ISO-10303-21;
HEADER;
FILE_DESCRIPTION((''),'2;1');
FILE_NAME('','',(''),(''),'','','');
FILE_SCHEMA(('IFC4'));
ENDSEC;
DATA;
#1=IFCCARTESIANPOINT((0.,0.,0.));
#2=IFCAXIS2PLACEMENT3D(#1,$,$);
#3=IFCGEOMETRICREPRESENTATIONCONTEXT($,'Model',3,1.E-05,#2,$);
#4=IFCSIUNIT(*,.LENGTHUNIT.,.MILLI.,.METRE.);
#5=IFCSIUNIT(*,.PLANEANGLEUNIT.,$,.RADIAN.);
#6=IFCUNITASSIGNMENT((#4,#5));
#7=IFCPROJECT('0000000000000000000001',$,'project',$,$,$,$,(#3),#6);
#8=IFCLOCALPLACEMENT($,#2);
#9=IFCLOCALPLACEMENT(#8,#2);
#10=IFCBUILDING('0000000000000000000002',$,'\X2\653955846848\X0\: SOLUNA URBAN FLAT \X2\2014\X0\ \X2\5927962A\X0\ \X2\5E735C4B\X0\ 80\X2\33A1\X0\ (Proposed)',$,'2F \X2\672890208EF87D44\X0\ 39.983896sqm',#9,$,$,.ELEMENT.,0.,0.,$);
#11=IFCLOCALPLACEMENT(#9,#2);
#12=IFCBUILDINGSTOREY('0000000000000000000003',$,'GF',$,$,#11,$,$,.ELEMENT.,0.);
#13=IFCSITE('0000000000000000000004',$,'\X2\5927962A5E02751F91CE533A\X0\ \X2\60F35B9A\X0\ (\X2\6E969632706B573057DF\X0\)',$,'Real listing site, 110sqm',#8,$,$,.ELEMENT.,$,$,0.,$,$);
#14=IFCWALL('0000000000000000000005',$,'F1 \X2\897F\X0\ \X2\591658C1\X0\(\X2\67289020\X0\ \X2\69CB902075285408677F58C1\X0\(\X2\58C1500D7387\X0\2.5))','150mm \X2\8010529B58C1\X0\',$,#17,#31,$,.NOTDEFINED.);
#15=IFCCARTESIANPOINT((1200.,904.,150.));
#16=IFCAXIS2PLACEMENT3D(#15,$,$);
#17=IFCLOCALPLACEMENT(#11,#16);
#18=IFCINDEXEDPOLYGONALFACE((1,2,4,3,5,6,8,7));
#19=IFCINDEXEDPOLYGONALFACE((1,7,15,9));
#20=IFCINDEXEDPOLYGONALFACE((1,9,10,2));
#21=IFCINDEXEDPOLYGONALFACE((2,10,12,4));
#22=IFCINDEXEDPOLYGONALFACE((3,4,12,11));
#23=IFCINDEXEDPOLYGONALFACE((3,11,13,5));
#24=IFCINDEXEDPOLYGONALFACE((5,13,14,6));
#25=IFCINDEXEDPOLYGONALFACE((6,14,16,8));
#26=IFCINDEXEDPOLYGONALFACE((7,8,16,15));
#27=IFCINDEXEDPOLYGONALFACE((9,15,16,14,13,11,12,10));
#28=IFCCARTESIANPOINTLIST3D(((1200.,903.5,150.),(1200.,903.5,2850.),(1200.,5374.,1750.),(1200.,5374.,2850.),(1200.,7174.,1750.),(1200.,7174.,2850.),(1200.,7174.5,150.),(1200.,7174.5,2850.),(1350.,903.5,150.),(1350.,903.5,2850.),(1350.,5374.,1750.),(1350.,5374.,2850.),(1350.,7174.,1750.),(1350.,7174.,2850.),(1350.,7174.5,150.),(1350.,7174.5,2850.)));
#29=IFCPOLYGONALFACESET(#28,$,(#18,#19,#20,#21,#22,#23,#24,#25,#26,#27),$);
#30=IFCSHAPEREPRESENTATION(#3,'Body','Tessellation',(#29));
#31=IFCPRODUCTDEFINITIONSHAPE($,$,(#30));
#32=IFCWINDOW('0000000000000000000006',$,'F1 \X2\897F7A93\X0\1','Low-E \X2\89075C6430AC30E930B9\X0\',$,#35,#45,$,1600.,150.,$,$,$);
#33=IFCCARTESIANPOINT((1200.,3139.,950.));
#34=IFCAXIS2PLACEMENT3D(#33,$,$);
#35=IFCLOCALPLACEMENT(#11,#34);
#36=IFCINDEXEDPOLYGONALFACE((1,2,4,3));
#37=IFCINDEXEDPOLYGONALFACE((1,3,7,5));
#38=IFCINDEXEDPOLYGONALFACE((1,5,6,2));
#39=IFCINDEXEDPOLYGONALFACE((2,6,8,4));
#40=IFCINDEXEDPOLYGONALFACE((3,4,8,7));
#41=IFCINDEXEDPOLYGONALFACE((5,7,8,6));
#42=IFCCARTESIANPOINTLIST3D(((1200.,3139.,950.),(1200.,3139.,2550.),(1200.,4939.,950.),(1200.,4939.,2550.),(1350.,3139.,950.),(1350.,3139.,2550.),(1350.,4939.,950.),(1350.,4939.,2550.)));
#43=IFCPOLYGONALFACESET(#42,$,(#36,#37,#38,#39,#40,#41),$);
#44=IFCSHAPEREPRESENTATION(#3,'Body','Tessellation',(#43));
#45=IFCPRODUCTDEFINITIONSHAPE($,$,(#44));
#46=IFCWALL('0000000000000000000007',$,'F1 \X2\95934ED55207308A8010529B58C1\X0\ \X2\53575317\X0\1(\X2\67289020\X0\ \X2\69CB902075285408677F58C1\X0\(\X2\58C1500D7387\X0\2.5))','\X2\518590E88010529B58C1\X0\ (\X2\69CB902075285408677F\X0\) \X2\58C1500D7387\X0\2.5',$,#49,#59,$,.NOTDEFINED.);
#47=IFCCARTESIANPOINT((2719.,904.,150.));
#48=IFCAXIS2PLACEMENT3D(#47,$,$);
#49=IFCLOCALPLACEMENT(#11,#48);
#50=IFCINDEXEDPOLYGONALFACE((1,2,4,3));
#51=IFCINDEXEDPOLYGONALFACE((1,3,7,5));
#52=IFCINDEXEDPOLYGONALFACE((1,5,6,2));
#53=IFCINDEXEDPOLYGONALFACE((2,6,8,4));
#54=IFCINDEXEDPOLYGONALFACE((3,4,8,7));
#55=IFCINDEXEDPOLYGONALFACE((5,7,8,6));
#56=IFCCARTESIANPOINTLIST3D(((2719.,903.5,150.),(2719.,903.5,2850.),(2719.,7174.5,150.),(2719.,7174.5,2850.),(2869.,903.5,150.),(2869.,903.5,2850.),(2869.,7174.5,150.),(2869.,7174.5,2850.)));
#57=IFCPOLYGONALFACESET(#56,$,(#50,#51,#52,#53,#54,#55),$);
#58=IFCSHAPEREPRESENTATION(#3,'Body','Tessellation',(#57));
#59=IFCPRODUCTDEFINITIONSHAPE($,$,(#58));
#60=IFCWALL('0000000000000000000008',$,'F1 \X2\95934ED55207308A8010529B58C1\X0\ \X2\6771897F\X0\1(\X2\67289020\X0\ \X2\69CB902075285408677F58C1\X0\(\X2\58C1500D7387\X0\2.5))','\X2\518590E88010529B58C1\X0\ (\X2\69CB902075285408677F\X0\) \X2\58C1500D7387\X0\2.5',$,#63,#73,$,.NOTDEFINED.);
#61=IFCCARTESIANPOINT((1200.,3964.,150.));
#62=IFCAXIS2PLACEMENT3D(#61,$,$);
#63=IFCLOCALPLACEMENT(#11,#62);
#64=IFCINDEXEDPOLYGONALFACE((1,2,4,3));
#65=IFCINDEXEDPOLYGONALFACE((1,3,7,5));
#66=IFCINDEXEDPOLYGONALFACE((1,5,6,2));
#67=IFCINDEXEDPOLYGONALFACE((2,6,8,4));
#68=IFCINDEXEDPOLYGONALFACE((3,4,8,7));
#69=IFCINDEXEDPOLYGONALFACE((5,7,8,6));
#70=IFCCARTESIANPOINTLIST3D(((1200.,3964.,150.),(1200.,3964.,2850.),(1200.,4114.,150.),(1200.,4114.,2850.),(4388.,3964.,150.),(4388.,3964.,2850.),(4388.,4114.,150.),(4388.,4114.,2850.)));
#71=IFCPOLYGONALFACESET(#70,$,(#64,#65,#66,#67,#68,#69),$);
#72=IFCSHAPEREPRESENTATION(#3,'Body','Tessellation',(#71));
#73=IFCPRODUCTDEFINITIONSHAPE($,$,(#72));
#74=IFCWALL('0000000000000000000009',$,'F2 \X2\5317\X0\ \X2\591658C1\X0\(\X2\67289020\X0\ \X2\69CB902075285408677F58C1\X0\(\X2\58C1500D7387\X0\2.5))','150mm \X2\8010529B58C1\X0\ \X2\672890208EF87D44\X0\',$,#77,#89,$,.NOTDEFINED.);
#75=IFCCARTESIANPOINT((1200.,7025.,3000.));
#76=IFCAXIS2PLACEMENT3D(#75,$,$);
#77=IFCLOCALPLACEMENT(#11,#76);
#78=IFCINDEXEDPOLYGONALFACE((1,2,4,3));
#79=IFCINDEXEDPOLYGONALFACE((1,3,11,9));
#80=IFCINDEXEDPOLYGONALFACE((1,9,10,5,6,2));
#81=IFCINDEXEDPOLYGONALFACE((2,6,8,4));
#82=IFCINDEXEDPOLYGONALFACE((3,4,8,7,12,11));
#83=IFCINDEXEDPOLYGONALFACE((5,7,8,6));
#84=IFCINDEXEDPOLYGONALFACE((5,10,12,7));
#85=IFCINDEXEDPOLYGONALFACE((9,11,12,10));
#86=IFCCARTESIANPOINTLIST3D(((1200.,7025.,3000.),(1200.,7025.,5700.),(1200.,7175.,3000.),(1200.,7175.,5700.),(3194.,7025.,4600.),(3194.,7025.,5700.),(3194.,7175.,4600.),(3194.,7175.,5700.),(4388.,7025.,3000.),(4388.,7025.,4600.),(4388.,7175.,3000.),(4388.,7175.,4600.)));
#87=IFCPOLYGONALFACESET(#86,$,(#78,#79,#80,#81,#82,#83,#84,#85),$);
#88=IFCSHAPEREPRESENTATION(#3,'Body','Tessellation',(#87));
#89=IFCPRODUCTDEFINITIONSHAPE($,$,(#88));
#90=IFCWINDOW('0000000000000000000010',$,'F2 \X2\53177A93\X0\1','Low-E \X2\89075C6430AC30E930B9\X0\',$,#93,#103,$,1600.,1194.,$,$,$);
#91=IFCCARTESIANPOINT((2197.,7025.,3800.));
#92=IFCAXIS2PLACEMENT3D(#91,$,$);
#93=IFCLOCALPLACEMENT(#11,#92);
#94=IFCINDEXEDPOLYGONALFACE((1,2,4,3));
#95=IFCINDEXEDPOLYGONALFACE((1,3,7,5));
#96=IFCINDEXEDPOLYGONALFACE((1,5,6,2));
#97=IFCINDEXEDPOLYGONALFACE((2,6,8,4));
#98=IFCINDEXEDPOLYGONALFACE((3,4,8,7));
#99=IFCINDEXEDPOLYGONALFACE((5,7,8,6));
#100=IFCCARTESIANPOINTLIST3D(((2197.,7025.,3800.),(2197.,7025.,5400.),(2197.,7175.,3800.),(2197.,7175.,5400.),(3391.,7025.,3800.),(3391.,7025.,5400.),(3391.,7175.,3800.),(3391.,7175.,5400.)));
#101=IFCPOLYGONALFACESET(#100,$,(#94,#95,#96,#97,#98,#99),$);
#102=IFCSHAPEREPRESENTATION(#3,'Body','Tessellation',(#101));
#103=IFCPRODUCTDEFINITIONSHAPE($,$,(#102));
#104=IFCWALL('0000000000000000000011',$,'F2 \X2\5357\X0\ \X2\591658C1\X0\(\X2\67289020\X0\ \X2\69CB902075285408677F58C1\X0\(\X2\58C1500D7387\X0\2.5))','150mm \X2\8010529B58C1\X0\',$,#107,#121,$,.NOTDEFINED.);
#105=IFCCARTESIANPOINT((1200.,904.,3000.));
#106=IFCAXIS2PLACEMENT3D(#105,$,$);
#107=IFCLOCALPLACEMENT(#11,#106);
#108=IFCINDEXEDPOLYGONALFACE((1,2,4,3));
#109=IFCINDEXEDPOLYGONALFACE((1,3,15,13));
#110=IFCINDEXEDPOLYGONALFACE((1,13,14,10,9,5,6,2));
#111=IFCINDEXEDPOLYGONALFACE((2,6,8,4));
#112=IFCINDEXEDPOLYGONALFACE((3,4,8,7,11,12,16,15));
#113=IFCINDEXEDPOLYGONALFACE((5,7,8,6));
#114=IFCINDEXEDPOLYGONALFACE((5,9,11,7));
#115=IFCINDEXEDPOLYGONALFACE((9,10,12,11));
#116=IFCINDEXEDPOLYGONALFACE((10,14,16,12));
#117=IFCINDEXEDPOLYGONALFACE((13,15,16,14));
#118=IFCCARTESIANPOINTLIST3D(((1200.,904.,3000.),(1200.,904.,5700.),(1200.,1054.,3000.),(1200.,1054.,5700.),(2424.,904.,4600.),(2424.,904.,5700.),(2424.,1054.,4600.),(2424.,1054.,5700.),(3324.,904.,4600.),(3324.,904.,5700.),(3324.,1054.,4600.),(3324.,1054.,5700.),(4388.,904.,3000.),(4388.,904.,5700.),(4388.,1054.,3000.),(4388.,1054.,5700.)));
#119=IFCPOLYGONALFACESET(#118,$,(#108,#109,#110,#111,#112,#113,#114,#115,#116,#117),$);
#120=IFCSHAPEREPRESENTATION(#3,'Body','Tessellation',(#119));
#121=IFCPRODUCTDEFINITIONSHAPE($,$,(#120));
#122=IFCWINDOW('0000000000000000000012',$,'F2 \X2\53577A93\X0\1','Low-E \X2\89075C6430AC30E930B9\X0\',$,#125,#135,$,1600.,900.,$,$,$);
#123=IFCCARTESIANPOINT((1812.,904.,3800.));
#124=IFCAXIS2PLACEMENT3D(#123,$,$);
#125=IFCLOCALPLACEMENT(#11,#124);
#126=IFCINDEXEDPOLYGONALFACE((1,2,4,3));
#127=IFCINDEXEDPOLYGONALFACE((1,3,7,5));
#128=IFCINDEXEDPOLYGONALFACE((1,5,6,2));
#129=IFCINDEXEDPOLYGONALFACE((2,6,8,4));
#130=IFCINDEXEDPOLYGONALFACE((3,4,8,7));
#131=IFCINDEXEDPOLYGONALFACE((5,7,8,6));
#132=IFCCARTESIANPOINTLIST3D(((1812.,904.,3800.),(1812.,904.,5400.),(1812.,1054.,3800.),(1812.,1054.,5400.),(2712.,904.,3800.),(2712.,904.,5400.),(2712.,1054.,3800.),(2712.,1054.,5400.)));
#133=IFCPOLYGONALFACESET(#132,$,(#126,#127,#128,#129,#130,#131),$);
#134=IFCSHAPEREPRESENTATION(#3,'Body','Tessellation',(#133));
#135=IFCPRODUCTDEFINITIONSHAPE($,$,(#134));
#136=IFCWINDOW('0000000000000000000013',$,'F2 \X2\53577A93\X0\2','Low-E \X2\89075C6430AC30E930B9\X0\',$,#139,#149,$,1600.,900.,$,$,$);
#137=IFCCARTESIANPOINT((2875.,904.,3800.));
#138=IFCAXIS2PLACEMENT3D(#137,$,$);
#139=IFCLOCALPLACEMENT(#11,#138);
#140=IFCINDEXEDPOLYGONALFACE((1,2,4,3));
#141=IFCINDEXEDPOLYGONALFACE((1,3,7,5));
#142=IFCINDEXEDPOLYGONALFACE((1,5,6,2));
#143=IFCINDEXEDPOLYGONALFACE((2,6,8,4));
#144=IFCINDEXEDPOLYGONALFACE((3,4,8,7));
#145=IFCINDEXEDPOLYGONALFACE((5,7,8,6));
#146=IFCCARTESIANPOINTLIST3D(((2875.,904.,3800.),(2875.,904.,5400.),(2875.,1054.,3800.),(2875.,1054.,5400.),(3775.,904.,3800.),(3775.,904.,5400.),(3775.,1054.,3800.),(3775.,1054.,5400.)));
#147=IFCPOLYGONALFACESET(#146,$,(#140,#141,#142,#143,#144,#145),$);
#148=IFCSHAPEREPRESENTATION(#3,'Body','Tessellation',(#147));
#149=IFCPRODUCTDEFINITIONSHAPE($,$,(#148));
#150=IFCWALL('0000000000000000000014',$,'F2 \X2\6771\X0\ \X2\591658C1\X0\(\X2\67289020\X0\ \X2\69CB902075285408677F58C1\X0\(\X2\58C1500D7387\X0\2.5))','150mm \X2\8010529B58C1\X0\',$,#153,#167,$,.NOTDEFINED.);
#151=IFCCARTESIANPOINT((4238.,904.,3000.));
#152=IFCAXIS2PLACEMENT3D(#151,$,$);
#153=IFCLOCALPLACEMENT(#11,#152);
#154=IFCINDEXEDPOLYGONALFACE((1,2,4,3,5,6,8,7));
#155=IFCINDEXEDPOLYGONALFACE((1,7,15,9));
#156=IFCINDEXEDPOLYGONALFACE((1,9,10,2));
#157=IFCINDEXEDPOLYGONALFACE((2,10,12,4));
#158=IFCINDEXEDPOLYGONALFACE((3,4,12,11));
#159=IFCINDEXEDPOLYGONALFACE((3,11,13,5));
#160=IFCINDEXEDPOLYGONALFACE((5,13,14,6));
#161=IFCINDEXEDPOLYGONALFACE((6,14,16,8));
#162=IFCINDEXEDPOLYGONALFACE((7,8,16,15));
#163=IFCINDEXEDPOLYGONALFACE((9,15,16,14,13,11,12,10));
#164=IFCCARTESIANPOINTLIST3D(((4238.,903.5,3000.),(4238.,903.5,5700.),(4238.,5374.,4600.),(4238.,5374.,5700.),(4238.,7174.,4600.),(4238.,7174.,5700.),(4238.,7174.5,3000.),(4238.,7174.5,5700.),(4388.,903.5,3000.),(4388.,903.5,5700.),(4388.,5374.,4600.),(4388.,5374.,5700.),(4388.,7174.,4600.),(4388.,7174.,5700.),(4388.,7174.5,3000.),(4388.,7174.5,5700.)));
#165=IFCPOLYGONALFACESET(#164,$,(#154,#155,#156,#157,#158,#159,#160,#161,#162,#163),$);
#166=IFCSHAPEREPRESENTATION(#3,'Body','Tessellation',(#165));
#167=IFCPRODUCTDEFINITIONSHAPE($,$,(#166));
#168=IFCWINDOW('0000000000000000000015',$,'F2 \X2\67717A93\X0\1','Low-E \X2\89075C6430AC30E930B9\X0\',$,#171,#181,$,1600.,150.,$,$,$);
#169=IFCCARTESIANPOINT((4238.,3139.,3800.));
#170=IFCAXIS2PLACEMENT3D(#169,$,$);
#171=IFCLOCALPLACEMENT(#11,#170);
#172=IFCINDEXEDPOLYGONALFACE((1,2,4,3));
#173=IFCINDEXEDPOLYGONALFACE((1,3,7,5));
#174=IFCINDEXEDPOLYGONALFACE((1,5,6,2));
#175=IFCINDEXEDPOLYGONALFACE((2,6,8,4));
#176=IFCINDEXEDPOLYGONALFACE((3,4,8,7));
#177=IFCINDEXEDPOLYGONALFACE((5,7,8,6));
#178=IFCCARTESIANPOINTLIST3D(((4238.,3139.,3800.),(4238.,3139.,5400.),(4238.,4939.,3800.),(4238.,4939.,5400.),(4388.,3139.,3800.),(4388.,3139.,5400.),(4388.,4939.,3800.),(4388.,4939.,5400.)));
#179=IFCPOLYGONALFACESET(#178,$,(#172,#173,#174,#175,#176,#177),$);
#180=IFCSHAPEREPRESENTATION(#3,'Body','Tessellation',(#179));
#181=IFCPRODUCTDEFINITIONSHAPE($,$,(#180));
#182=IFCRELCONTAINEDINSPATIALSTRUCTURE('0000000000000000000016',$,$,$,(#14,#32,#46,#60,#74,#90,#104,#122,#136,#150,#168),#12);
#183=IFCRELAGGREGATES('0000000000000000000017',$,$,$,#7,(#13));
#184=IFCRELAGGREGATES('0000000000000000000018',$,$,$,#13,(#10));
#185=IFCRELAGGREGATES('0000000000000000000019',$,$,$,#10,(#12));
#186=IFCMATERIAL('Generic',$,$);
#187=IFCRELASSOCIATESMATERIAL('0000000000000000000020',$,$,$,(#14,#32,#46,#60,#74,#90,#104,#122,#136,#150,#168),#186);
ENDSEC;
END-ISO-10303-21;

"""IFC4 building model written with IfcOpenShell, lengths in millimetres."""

from ifc_helpers import new_model, si_unit, frame, frame_2d, origin, place, context, project, spatial, rectangle, extrude, material, element, fill, save


model = new_model("IFC4")

# Units and contexts
model_context = context("Model", 3, precision=1e-05, world=origin())
ifc_project = project(units=[si_unit("LENGTHUNIT", "METRE", prefix="MILLI"), si_unit("PLANEANGLEUNIT", "RADIAN")], contexts=[model_context])

# Site, building, storey
site_placement = place(None, origin())
site = spatial("IfcSite", under=ifc_project, at=site_placement, Name="大阪市生野区 想定 (準防火地域)", ObjectType="Real listing site, 110sqm", CompositionType="ELEMENT", RefElevation=0.0)
building_placement = place(site_placement, origin())
building = spatial("IfcBuilding", under=site, at=building_placement, Name="改善案: SOLUNA URBAN FLAT — 大阪 平屋 80㎡ (Proposed)", ObjectType="2F 木造軸組 39.983896sqm", CompositionType="ELEMENT", ElevationOfRefHeight=0.0, ElevationOfTerrain=0.0)
storey_placement = place(building_placement, origin())
storey = spatial("IfcBuildingStorey", under=building, at=storey_placement, Name="GF", CompositionType="ELEMENT", Elevation=0.0)

# Shared definitions
ifc_material_1 = material(Name="Generic")

# Wall, opening, window
wall_1_placement = place(storey_placement, frame((1200.0, 904.0, 150.0)))
wall_1 = element("IfcWall", 1, at=wall_1_placement, inside=storey, material=ifc_material_1, Name="F1 西 外壁(木造 構造用合板壁(壁倍率2.5))", Description="150mm 耐力壁", PredefinedType="NOTDEFINED", context=model_context, shape_type="SweptSolid", body=[
    extrude(rectangle(XDim=150.0, YDim=6271.0, at=frame_2d((75.0, 3135.0))), frame((1200.0, 904.0, 150.0)), (0.0, 0.0, 1.0), 2700.0),
])
opening_1_placement = place(storey_placement, frame((1200.0, 3139.0, 950.0)))
opening_1 = element("IfcOpeningElement", 2, at=opening_1_placement, cuts=wall_1, PredefinedType="NOTDEFINED", context=model_context, shape_type="SweptSolid", body=[
    extrude(rectangle(XDim=150.0, YDim=1800.0, at=frame_2d((75.0, 900.0))), frame((1200.0, 3139.0, 950.0)), (0.0, 0.0, 1.0), 1600.0),
])
window_1_placement = place(storey_placement, frame((1200.0, 3139.0, 950.0)))
window_1 = element("IfcWindow", 3, at=window_1_placement, inside=storey, material=ifc_material_1, Name="F1 西窓1", Description="Low-E 複層ガラス", OverallHeight=1600.0, OverallWidth=150.0, context=model_context, shape_type="SweptSolid", body=[
    extrude(rectangle(XDim=150.0, YDim=1800.0, at=frame_2d((75.0, 900.0))), frame((1200.0, 3139.0, 950.0)), (0.0, 0.0, 1.0), 1600.0),
])
fill(opening_1, window_1)

# Walls
wall_2_placement = place(storey_placement, frame((2719.0, 904.0, 150.0)))
element("IfcWall", 4, at=wall_2_placement, inside=storey, material=ifc_material_1, Name="F1 間仕切り耐力壁 南北1(木造 構造用合板壁(壁倍率2.5))", Description="内部耐力壁 (構造用合板) 壁倍率2.5", PredefinedType="NOTDEFINED", context=model_context, shape_type="SweptSolid", body=[
    extrude(rectangle(XDim=150.0, YDim=6271.0, at=frame_2d((75.0, 3135.0))), frame((2719.0, 904.0, 150.0)), (0.0, 0.0, 1.0), 2700.0),
])
wall_3_placement = place(storey_placement, frame((1200.0, 3964.0, 150.0)))
element("IfcWall", 5, at=wall_3_placement, inside=storey, material=ifc_material_1, Name="F1 間仕切り耐力壁 東西1(木造 構造用合板壁(壁倍率2.5))", Description="内部耐力壁 (構造用合板) 壁倍率2.5", PredefinedType="NOTDEFINED", context=model_context, shape_type="SweptSolid", body=[
    extrude(rectangle(XDim=3188.0, YDim=150.0, at=frame_2d((1594.0, 75.0))), frame((1200.0, 3964.0, 150.0)), (0.0, 0.0, 1.0), 2700.0),
])

# Wall, opening, window
wall_4_placement = place(storey_placement, frame((1200.0, 7025.0, 3000.0)))
wall_4 = element("IfcWall", 6, at=wall_4_placement, inside=storey, material=ifc_material_1, Name="F2 北 外壁(木造 構造用合板壁(壁倍率2.5))", Description="150mm 耐力壁 木造軸組", PredefinedType="NOTDEFINED", context=model_context, shape_type="SweptSolid", body=[
    extrude(rectangle(XDim=3188.0, YDim=150.0, at=frame_2d((1594.0, 75.0))), frame((1200.0, 7025.0, 3000.0)), (0.0, 0.0, 1.0), 2700.0),
])
opening_2_placement = place(storey_placement, frame((2197.0, 7025.0, 3800.0)))
opening_2 = element("IfcOpeningElement", 7, at=opening_2_placement, cuts=wall_4, PredefinedType="NOTDEFINED", context=model_context, shape_type="SweptSolid", body=[
    extrude(rectangle(XDim=1194.0, YDim=150.0, at=frame_2d((597.0, 75.0))), frame((2197.0, 7025.0, 3800.0)), (0.0, 0.0, 1.0), 1600.0),
])
window_2_placement = place(storey_placement, frame((2197.0, 7025.0, 3800.0)))
window_2 = element("IfcWindow", 8, at=window_2_placement, inside=storey, material=ifc_material_1, Name="F2 北窓1", Description="Low-E 複層ガラス", OverallHeight=1600.0, OverallWidth=1194.0, context=model_context, shape_type="SweptSolid", body=[
    extrude(rectangle(XDim=1194.0, YDim=150.0, at=frame_2d((597.0, 75.0))), frame((2197.0, 7025.0, 3800.0)), (0.0, 0.0, 1.0), 1600.0),
])
fill(opening_2, window_2)

# Wall, openings, windows
wall_5_placement = place(storey_placement, frame((1200.0, 904.0, 3000.0)))
wall_5 = element("IfcWall", 9, at=wall_5_placement, inside=storey, material=ifc_material_1, Name="F2 南 外壁(木造 構造用合板壁(壁倍率2.5))", Description="150mm 耐力壁", PredefinedType="NOTDEFINED", context=model_context, shape_type="SweptSolid", body=[
    extrude(rectangle(XDim=3188.0, YDim=150.0, at=frame_2d((1594.0, 75.0))), frame((1200.0, 904.0, 3000.0)), (0.0, 0.0, 1.0), 2700.0),
])
opening_3_placement = place(storey_placement, frame((1812.0, 904.0, 3800.0)))
opening_3 = element("IfcOpeningElement", 10, at=opening_3_placement, cuts=wall_5, PredefinedType="NOTDEFINED", context=model_context, shape_type="SweptSolid", body=[
    extrude(rectangle(XDim=900.0, YDim=150.0, at=frame_2d((450.0, 75.0))), frame((1812.0, 904.0, 3800.0)), (0.0, 0.0, 1.0), 1600.0),
])
opening_4_placement = place(storey_placement, frame((2875.0, 904.0, 3800.0)))
opening_4 = element("IfcOpeningElement", 11, at=opening_4_placement, cuts=wall_5, PredefinedType="NOTDEFINED", context=model_context, shape_type="SweptSolid", body=[
    extrude(rectangle(XDim=900.0, YDim=150.0, at=frame_2d((450.0, 75.0))), frame((2875.0, 904.0, 3800.0)), (0.0, 0.0, 1.0), 1600.0),
])
window_3_placement = place(storey_placement, frame((1812.0, 904.0, 3800.0)))
window_3 = element("IfcWindow", 12, at=window_3_placement, inside=storey, material=ifc_material_1, Name="F2 南窓1", Description="Low-E 複層ガラス", OverallHeight=1600.0, OverallWidth=900.0, context=model_context, shape_type="SweptSolid", body=[
    extrude(rectangle(XDim=900.0, YDim=150.0, at=frame_2d((450.0, 75.0))), frame((1812.0, 904.0, 3800.0)), (0.0, 0.0, 1.0), 1600.0),
])
fill(opening_3, window_3)
window_4_placement = place(storey_placement, frame((2875.0, 904.0, 3800.0)))
window_4 = element("IfcWindow", 13, at=window_4_placement, inside=storey, material=ifc_material_1, Name="F2 南窓2", Description="Low-E 複層ガラス", OverallHeight=1600.0, OverallWidth=900.0, context=model_context, shape_type="SweptSolid", body=[
    extrude(rectangle(XDim=900.0, YDim=150.0, at=frame_2d((450.0, 75.0))), frame((2875.0, 904.0, 3800.0)), (0.0, 0.0, 1.0), 1600.0),
])
fill(opening_4, window_4)

# Wall, opening, window
wall_6_placement = place(storey_placement, frame((4238.0, 904.0, 3000.0)))
wall_6 = element("IfcWall", 14, at=wall_6_placement, inside=storey, material=ifc_material_1, Name="F2 東 外壁(木造 構造用合板壁(壁倍率2.5))", Description="150mm 耐力壁", PredefinedType="NOTDEFINED", context=model_context, shape_type="SweptSolid", body=[
    extrude(rectangle(XDim=150.0, YDim=6271.0, at=frame_2d((75.0, 3135.0))), frame((4238.0, 904.0, 3000.0)), (0.0, 0.0, 1.0), 2700.0),
])
opening_5_placement = place(storey_placement, frame((4238.0, 3139.0, 3800.0)))
opening_5 = element("IfcOpeningElement", 15, at=opening_5_placement, cuts=wall_6, PredefinedType="NOTDEFINED", context=model_context, shape_type="SweptSolid", body=[
    extrude(rectangle(XDim=150.0, YDim=1800.0, at=frame_2d((75.0, 900.0))), frame((4238.0, 3139.0, 3800.0)), (0.0, 0.0, 1.0), 1600.0),
])
window_5_placement = place(storey_placement, frame((4238.0, 3139.0, 3800.0)))
window_5 = element("IfcWindow", 16, at=window_5_placement, inside=storey, material=ifc_material_1, Name="F2 東窓1", Description="Low-E 複層ガラス", OverallHeight=1600.0, OverallWidth=150.0, context=model_context, shape_type="SweptSolid", body=[
    extrude(rectangle(XDim=150.0, YDim=1800.0, at=frame_2d((75.0, 900.0))), frame((4238.0, 3139.0, 3800.0)), (0.0, 0.0, 1.0), 1600.0),
])
fill(opening_5, window_5)

save(model, "model.ifc")
